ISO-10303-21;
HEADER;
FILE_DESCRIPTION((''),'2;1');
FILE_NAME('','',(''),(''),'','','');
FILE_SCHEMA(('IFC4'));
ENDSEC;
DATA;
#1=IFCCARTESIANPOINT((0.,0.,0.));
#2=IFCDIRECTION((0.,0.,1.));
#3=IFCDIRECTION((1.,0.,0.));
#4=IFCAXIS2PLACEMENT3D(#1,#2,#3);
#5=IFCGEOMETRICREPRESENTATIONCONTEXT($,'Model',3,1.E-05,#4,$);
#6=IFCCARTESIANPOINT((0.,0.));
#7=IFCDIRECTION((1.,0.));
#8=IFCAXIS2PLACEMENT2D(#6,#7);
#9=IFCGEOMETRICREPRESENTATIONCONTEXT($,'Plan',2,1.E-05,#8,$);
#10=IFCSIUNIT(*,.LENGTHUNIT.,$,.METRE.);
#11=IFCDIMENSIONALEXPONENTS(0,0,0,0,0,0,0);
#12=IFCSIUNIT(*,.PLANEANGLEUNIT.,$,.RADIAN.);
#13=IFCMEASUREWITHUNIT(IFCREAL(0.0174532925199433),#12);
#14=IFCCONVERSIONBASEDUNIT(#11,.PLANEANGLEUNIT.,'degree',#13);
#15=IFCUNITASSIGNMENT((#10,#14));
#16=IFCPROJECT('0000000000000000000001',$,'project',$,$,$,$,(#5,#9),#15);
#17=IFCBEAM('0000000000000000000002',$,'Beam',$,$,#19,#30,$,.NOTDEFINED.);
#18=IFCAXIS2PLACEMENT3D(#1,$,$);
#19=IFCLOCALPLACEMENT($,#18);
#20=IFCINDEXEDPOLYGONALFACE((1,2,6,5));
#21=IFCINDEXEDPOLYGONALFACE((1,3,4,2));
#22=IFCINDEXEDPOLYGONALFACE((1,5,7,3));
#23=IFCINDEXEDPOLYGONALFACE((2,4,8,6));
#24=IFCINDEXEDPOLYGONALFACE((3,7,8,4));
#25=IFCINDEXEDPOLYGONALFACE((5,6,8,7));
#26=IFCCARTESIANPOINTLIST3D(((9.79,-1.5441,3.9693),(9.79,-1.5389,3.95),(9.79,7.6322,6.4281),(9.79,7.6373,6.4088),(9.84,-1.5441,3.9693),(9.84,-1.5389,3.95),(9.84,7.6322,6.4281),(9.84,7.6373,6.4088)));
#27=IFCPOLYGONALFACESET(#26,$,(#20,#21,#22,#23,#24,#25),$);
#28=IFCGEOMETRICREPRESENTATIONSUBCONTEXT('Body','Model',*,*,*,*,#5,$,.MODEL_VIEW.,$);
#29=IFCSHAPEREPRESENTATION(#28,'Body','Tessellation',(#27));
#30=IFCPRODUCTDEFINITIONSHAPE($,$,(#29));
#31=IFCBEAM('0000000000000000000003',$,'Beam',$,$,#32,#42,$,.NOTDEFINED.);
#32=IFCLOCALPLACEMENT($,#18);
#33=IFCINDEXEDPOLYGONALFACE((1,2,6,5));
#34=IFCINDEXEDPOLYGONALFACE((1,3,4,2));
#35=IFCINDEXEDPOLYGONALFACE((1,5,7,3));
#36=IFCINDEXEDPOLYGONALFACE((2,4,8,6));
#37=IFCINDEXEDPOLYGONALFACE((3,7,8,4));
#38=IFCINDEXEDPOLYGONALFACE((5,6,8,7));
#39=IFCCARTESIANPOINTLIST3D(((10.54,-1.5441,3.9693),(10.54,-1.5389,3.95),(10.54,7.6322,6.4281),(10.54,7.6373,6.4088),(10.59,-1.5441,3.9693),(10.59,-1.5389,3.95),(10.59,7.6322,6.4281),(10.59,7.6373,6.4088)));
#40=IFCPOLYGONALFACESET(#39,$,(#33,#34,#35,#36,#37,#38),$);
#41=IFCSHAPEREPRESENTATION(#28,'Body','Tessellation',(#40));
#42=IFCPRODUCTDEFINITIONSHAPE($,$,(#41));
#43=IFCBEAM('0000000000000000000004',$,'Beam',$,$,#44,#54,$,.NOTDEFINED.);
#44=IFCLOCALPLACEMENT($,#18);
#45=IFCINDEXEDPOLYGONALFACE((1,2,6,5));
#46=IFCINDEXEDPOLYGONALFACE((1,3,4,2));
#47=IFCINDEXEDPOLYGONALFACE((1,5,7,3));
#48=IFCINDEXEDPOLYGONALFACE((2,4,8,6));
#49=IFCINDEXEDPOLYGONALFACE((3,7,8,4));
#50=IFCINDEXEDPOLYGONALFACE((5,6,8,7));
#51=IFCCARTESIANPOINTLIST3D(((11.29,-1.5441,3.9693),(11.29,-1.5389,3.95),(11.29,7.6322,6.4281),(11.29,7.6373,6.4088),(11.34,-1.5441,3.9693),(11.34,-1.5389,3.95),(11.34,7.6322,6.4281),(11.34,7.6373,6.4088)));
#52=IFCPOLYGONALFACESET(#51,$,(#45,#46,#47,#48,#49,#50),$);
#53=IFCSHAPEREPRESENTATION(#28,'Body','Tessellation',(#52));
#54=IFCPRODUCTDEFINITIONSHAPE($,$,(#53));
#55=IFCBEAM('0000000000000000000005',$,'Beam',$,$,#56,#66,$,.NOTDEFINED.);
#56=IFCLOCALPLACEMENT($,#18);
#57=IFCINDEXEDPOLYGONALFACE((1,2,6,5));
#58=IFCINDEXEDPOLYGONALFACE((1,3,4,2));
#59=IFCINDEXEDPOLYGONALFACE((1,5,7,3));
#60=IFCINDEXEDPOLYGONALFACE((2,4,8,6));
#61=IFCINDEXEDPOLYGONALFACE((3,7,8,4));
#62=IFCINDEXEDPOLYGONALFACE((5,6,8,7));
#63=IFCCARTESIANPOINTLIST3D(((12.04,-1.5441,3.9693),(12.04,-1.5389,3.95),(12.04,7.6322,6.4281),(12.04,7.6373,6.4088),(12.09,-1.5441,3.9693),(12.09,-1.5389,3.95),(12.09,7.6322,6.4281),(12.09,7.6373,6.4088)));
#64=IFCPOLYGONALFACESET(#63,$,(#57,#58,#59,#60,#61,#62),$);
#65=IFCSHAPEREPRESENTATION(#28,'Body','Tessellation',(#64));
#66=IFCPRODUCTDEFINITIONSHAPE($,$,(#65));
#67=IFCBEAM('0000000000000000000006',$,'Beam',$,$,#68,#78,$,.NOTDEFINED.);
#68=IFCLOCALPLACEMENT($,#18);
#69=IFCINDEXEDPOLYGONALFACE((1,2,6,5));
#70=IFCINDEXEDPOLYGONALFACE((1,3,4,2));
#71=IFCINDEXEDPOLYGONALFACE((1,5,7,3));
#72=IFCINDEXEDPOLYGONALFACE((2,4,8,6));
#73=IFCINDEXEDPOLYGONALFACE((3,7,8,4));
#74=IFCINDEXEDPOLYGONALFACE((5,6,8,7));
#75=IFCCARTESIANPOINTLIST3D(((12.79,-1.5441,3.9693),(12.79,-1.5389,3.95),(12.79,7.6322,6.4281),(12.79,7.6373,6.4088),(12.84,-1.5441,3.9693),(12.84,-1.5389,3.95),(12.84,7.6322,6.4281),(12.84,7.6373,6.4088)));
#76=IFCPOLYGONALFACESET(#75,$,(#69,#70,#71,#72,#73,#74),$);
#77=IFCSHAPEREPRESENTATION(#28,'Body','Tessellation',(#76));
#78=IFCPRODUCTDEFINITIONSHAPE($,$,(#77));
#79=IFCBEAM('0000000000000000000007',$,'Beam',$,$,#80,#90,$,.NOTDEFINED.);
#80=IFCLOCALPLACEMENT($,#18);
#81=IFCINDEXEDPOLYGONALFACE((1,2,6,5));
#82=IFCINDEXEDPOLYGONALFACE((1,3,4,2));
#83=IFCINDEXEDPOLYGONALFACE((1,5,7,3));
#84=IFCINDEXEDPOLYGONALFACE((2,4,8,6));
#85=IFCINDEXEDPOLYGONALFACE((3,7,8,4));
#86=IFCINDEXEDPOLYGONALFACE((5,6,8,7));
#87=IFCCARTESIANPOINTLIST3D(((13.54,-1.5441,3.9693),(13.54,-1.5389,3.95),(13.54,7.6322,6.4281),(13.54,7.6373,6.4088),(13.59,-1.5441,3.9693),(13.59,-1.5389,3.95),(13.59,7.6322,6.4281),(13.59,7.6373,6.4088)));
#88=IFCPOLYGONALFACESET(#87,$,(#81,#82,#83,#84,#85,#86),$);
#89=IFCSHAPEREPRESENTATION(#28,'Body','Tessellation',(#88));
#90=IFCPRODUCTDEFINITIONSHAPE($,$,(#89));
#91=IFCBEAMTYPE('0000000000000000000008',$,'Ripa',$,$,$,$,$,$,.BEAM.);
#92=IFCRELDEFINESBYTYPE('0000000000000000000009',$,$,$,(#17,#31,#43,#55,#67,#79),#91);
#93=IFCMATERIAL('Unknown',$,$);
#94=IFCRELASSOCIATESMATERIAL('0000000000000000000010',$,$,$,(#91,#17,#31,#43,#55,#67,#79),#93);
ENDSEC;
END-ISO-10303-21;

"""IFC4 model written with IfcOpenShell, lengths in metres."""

from ifc_helpers import new_model, entity, si_unit, converted_unit, frame, origin_with_axes, origin_2d_with_axis, place, context, subcontext, project, rectangle, extrude, material, material_profile, profile_set, profile_usage, type_object, element, save


model = new_model("IFC4")

# Units and contexts
model_context = context("Model", 3, precision=1e-05, world=origin_with_axes())
plan_context = context("Plan", 2, precision=1e-05, world=origin_2d_with_axis())
body_context = subcontext(model_context, "Body", "Model", "MODEL_VIEW")
ifc_project = project(units=[si_unit("LENGTHUNIT", "METRE"), converted_unit("PLANEANGLEUNIT", "degree", entity("IfcReal", 0.0174532925199433), si_unit("PLANEANGLEUNIT", "RADIAN"), dimensions=[0, 0, 0, 0, 0, 0, 0])], contexts=[model_context, plan_context])

# Beams
ifc_material = material(Name="Unknown")
ifc_material_profile = material_profile(ifc_material, rectangle(XDim=0.05, YDim=0.02))
ifc_profile_set = profile_set([ifc_material_profile])
beam_type = type_object("IfcBeamType", Name="Ripa", PredefinedType="BEAM", material=ifc_profile_set)
ifc_profile_usage_1 = profile_usage(ifc_profile_set, cardinal=2)
beam_1_placement = place(None, frame((9.815, -1.5389, 3.95), z_axis=(-0.000001, 0.965926, 0.25882), x_axis=(-1.0, -0.000001, 0.0)))
element("IfcBeam", 1, at=beam_1_placement, type_object=beam_type, material=ifc_profile_usage_1, Name="Beam", PredefinedType="NOTDEFINED", context=body_context, shape_type="SweptSolid", body=[
    extrude(rectangle(XDim=0.05, YDim=0.02), frame((0.0, 0.01, 0.0), z_axis=(0.0, 0.0, 1.0), x_axis=(1.0, 0.0, 0.0)), (0.0, 0.0, 1.0), 9.4999),
])
ifc_profile_usage_2 = profile_usage(ifc_profile_set, cardinal=2)
beam_2_placement = place(None, frame((10.565, -1.5389, 3.95), z_axis=(-0.000001, 0.965926, 0.25882), x_axis=(-1.0, -0.000001, 0.0)))
element("IfcBeam", 2, at=beam_2_placement, type_object=beam_type, material=ifc_profile_usage_2, Name="Beam", PredefinedType="NOTDEFINED", context=body_context, shape_type="SweptSolid", body=[
    extrude(rectangle(XDim=0.05, YDim=0.02), frame((0.0, 0.01, 0.0), z_axis=(0.0, 0.0, 1.0), x_axis=(1.0, 0.0, 0.0)), (0.0, 0.0, 1.0), 9.4999),
])
ifc_profile_usage_3 = profile_usage(ifc_profile_set, cardinal=2)
beam_3_placement = place(None, frame((11.315, -1.5389, 3.95), z_axis=(-0.000001, 0.965926, 0.25882), x_axis=(-1.0, -0.000001, 0.0)))
element("IfcBeam", 3, at=beam_3_placement, type_object=beam_type, material=ifc_profile_usage_3, Name="Beam", PredefinedType="NOTDEFINED", context=body_context, shape_type="SweptSolid", body=[
    extrude(rectangle(XDim=0.05, YDim=0.02), frame((0.0, 0.01, 0.0), z_axis=(0.0, 0.0, 1.0), x_axis=(1.0, 0.0, 0.0)), (0.0, 0.0, 1.0), 9.4999),
])
ifc_profile_usage_4 = profile_usage(ifc_profile_set, cardinal=2)
beam_4_placement = place(None, frame((12.065, -1.5389, 3.95), z_axis=(-0.000001, 0.965926, 0.25882), x_axis=(-1.0, -0.000001, 0.0)))
element("IfcBeam", 4, at=beam_4_placement, type_object=beam_type, material=ifc_profile_usage_4, Name="Beam", PredefinedType="NOTDEFINED", context=body_context, shape_type="SweptSolid", body=[
    extrude(rectangle(XDim=0.05, YDim=0.02), frame((0.0, 0.01, 0.0), z_axis=(0.0, 0.0, 1.0), x_axis=(1.0, 0.0, 0.0)), (0.0, 0.0, 1.0), 9.4999),
])
ifc_profile_usage_5 = profile_usage(ifc_profile_set, cardinal=2)
beam_5_placement = place(None, frame((12.815, -1.5389, 3.95), z_axis=(-0.000001, 0.965926, 0.25882), x_axis=(-1.0, -0.000001, 0.0)))
element("IfcBeam", 5, at=beam_5_placement, type_object=beam_type, material=ifc_profile_usage_5, Name="Beam", PredefinedType="NOTDEFINED", context=body_context, shape_type="SweptSolid", body=[
    extrude(rectangle(XDim=0.05, YDim=0.02), frame((0.0, 0.01, 0.0), z_axis=(0.0, 0.0, 1.0), x_axis=(1.0, 0.0, 0.0)), (0.0, 0.0, 1.0), 9.4999),
])
ifc_profile_usage_6 = profile_usage(ifc_profile_set, cardinal=2)
beam_6_placement = place(None, frame((13.565, -1.5389, 3.95), z_axis=(-0.000001, 0.965926, 0.25882), x_axis=(-1.0, -0.000001, 0.0)))
element("IfcBeam", 6, at=beam_6_placement, type_object=beam_type, material=ifc_profile_usage_6, Name="Beam", PredefinedType="NOTDEFINED", context=body_context, shape_type="SweptSolid", body=[
    extrude(rectangle(XDim=0.05, YDim=0.02), frame((0.0, 0.01, 0.0), z_axis=(0.0, 0.0, 1.0), x_axis=(1.0, 0.0, 0.0)), (0.0, 0.0, 1.0), 9.4999),
])

save(model, "model.ifc")
